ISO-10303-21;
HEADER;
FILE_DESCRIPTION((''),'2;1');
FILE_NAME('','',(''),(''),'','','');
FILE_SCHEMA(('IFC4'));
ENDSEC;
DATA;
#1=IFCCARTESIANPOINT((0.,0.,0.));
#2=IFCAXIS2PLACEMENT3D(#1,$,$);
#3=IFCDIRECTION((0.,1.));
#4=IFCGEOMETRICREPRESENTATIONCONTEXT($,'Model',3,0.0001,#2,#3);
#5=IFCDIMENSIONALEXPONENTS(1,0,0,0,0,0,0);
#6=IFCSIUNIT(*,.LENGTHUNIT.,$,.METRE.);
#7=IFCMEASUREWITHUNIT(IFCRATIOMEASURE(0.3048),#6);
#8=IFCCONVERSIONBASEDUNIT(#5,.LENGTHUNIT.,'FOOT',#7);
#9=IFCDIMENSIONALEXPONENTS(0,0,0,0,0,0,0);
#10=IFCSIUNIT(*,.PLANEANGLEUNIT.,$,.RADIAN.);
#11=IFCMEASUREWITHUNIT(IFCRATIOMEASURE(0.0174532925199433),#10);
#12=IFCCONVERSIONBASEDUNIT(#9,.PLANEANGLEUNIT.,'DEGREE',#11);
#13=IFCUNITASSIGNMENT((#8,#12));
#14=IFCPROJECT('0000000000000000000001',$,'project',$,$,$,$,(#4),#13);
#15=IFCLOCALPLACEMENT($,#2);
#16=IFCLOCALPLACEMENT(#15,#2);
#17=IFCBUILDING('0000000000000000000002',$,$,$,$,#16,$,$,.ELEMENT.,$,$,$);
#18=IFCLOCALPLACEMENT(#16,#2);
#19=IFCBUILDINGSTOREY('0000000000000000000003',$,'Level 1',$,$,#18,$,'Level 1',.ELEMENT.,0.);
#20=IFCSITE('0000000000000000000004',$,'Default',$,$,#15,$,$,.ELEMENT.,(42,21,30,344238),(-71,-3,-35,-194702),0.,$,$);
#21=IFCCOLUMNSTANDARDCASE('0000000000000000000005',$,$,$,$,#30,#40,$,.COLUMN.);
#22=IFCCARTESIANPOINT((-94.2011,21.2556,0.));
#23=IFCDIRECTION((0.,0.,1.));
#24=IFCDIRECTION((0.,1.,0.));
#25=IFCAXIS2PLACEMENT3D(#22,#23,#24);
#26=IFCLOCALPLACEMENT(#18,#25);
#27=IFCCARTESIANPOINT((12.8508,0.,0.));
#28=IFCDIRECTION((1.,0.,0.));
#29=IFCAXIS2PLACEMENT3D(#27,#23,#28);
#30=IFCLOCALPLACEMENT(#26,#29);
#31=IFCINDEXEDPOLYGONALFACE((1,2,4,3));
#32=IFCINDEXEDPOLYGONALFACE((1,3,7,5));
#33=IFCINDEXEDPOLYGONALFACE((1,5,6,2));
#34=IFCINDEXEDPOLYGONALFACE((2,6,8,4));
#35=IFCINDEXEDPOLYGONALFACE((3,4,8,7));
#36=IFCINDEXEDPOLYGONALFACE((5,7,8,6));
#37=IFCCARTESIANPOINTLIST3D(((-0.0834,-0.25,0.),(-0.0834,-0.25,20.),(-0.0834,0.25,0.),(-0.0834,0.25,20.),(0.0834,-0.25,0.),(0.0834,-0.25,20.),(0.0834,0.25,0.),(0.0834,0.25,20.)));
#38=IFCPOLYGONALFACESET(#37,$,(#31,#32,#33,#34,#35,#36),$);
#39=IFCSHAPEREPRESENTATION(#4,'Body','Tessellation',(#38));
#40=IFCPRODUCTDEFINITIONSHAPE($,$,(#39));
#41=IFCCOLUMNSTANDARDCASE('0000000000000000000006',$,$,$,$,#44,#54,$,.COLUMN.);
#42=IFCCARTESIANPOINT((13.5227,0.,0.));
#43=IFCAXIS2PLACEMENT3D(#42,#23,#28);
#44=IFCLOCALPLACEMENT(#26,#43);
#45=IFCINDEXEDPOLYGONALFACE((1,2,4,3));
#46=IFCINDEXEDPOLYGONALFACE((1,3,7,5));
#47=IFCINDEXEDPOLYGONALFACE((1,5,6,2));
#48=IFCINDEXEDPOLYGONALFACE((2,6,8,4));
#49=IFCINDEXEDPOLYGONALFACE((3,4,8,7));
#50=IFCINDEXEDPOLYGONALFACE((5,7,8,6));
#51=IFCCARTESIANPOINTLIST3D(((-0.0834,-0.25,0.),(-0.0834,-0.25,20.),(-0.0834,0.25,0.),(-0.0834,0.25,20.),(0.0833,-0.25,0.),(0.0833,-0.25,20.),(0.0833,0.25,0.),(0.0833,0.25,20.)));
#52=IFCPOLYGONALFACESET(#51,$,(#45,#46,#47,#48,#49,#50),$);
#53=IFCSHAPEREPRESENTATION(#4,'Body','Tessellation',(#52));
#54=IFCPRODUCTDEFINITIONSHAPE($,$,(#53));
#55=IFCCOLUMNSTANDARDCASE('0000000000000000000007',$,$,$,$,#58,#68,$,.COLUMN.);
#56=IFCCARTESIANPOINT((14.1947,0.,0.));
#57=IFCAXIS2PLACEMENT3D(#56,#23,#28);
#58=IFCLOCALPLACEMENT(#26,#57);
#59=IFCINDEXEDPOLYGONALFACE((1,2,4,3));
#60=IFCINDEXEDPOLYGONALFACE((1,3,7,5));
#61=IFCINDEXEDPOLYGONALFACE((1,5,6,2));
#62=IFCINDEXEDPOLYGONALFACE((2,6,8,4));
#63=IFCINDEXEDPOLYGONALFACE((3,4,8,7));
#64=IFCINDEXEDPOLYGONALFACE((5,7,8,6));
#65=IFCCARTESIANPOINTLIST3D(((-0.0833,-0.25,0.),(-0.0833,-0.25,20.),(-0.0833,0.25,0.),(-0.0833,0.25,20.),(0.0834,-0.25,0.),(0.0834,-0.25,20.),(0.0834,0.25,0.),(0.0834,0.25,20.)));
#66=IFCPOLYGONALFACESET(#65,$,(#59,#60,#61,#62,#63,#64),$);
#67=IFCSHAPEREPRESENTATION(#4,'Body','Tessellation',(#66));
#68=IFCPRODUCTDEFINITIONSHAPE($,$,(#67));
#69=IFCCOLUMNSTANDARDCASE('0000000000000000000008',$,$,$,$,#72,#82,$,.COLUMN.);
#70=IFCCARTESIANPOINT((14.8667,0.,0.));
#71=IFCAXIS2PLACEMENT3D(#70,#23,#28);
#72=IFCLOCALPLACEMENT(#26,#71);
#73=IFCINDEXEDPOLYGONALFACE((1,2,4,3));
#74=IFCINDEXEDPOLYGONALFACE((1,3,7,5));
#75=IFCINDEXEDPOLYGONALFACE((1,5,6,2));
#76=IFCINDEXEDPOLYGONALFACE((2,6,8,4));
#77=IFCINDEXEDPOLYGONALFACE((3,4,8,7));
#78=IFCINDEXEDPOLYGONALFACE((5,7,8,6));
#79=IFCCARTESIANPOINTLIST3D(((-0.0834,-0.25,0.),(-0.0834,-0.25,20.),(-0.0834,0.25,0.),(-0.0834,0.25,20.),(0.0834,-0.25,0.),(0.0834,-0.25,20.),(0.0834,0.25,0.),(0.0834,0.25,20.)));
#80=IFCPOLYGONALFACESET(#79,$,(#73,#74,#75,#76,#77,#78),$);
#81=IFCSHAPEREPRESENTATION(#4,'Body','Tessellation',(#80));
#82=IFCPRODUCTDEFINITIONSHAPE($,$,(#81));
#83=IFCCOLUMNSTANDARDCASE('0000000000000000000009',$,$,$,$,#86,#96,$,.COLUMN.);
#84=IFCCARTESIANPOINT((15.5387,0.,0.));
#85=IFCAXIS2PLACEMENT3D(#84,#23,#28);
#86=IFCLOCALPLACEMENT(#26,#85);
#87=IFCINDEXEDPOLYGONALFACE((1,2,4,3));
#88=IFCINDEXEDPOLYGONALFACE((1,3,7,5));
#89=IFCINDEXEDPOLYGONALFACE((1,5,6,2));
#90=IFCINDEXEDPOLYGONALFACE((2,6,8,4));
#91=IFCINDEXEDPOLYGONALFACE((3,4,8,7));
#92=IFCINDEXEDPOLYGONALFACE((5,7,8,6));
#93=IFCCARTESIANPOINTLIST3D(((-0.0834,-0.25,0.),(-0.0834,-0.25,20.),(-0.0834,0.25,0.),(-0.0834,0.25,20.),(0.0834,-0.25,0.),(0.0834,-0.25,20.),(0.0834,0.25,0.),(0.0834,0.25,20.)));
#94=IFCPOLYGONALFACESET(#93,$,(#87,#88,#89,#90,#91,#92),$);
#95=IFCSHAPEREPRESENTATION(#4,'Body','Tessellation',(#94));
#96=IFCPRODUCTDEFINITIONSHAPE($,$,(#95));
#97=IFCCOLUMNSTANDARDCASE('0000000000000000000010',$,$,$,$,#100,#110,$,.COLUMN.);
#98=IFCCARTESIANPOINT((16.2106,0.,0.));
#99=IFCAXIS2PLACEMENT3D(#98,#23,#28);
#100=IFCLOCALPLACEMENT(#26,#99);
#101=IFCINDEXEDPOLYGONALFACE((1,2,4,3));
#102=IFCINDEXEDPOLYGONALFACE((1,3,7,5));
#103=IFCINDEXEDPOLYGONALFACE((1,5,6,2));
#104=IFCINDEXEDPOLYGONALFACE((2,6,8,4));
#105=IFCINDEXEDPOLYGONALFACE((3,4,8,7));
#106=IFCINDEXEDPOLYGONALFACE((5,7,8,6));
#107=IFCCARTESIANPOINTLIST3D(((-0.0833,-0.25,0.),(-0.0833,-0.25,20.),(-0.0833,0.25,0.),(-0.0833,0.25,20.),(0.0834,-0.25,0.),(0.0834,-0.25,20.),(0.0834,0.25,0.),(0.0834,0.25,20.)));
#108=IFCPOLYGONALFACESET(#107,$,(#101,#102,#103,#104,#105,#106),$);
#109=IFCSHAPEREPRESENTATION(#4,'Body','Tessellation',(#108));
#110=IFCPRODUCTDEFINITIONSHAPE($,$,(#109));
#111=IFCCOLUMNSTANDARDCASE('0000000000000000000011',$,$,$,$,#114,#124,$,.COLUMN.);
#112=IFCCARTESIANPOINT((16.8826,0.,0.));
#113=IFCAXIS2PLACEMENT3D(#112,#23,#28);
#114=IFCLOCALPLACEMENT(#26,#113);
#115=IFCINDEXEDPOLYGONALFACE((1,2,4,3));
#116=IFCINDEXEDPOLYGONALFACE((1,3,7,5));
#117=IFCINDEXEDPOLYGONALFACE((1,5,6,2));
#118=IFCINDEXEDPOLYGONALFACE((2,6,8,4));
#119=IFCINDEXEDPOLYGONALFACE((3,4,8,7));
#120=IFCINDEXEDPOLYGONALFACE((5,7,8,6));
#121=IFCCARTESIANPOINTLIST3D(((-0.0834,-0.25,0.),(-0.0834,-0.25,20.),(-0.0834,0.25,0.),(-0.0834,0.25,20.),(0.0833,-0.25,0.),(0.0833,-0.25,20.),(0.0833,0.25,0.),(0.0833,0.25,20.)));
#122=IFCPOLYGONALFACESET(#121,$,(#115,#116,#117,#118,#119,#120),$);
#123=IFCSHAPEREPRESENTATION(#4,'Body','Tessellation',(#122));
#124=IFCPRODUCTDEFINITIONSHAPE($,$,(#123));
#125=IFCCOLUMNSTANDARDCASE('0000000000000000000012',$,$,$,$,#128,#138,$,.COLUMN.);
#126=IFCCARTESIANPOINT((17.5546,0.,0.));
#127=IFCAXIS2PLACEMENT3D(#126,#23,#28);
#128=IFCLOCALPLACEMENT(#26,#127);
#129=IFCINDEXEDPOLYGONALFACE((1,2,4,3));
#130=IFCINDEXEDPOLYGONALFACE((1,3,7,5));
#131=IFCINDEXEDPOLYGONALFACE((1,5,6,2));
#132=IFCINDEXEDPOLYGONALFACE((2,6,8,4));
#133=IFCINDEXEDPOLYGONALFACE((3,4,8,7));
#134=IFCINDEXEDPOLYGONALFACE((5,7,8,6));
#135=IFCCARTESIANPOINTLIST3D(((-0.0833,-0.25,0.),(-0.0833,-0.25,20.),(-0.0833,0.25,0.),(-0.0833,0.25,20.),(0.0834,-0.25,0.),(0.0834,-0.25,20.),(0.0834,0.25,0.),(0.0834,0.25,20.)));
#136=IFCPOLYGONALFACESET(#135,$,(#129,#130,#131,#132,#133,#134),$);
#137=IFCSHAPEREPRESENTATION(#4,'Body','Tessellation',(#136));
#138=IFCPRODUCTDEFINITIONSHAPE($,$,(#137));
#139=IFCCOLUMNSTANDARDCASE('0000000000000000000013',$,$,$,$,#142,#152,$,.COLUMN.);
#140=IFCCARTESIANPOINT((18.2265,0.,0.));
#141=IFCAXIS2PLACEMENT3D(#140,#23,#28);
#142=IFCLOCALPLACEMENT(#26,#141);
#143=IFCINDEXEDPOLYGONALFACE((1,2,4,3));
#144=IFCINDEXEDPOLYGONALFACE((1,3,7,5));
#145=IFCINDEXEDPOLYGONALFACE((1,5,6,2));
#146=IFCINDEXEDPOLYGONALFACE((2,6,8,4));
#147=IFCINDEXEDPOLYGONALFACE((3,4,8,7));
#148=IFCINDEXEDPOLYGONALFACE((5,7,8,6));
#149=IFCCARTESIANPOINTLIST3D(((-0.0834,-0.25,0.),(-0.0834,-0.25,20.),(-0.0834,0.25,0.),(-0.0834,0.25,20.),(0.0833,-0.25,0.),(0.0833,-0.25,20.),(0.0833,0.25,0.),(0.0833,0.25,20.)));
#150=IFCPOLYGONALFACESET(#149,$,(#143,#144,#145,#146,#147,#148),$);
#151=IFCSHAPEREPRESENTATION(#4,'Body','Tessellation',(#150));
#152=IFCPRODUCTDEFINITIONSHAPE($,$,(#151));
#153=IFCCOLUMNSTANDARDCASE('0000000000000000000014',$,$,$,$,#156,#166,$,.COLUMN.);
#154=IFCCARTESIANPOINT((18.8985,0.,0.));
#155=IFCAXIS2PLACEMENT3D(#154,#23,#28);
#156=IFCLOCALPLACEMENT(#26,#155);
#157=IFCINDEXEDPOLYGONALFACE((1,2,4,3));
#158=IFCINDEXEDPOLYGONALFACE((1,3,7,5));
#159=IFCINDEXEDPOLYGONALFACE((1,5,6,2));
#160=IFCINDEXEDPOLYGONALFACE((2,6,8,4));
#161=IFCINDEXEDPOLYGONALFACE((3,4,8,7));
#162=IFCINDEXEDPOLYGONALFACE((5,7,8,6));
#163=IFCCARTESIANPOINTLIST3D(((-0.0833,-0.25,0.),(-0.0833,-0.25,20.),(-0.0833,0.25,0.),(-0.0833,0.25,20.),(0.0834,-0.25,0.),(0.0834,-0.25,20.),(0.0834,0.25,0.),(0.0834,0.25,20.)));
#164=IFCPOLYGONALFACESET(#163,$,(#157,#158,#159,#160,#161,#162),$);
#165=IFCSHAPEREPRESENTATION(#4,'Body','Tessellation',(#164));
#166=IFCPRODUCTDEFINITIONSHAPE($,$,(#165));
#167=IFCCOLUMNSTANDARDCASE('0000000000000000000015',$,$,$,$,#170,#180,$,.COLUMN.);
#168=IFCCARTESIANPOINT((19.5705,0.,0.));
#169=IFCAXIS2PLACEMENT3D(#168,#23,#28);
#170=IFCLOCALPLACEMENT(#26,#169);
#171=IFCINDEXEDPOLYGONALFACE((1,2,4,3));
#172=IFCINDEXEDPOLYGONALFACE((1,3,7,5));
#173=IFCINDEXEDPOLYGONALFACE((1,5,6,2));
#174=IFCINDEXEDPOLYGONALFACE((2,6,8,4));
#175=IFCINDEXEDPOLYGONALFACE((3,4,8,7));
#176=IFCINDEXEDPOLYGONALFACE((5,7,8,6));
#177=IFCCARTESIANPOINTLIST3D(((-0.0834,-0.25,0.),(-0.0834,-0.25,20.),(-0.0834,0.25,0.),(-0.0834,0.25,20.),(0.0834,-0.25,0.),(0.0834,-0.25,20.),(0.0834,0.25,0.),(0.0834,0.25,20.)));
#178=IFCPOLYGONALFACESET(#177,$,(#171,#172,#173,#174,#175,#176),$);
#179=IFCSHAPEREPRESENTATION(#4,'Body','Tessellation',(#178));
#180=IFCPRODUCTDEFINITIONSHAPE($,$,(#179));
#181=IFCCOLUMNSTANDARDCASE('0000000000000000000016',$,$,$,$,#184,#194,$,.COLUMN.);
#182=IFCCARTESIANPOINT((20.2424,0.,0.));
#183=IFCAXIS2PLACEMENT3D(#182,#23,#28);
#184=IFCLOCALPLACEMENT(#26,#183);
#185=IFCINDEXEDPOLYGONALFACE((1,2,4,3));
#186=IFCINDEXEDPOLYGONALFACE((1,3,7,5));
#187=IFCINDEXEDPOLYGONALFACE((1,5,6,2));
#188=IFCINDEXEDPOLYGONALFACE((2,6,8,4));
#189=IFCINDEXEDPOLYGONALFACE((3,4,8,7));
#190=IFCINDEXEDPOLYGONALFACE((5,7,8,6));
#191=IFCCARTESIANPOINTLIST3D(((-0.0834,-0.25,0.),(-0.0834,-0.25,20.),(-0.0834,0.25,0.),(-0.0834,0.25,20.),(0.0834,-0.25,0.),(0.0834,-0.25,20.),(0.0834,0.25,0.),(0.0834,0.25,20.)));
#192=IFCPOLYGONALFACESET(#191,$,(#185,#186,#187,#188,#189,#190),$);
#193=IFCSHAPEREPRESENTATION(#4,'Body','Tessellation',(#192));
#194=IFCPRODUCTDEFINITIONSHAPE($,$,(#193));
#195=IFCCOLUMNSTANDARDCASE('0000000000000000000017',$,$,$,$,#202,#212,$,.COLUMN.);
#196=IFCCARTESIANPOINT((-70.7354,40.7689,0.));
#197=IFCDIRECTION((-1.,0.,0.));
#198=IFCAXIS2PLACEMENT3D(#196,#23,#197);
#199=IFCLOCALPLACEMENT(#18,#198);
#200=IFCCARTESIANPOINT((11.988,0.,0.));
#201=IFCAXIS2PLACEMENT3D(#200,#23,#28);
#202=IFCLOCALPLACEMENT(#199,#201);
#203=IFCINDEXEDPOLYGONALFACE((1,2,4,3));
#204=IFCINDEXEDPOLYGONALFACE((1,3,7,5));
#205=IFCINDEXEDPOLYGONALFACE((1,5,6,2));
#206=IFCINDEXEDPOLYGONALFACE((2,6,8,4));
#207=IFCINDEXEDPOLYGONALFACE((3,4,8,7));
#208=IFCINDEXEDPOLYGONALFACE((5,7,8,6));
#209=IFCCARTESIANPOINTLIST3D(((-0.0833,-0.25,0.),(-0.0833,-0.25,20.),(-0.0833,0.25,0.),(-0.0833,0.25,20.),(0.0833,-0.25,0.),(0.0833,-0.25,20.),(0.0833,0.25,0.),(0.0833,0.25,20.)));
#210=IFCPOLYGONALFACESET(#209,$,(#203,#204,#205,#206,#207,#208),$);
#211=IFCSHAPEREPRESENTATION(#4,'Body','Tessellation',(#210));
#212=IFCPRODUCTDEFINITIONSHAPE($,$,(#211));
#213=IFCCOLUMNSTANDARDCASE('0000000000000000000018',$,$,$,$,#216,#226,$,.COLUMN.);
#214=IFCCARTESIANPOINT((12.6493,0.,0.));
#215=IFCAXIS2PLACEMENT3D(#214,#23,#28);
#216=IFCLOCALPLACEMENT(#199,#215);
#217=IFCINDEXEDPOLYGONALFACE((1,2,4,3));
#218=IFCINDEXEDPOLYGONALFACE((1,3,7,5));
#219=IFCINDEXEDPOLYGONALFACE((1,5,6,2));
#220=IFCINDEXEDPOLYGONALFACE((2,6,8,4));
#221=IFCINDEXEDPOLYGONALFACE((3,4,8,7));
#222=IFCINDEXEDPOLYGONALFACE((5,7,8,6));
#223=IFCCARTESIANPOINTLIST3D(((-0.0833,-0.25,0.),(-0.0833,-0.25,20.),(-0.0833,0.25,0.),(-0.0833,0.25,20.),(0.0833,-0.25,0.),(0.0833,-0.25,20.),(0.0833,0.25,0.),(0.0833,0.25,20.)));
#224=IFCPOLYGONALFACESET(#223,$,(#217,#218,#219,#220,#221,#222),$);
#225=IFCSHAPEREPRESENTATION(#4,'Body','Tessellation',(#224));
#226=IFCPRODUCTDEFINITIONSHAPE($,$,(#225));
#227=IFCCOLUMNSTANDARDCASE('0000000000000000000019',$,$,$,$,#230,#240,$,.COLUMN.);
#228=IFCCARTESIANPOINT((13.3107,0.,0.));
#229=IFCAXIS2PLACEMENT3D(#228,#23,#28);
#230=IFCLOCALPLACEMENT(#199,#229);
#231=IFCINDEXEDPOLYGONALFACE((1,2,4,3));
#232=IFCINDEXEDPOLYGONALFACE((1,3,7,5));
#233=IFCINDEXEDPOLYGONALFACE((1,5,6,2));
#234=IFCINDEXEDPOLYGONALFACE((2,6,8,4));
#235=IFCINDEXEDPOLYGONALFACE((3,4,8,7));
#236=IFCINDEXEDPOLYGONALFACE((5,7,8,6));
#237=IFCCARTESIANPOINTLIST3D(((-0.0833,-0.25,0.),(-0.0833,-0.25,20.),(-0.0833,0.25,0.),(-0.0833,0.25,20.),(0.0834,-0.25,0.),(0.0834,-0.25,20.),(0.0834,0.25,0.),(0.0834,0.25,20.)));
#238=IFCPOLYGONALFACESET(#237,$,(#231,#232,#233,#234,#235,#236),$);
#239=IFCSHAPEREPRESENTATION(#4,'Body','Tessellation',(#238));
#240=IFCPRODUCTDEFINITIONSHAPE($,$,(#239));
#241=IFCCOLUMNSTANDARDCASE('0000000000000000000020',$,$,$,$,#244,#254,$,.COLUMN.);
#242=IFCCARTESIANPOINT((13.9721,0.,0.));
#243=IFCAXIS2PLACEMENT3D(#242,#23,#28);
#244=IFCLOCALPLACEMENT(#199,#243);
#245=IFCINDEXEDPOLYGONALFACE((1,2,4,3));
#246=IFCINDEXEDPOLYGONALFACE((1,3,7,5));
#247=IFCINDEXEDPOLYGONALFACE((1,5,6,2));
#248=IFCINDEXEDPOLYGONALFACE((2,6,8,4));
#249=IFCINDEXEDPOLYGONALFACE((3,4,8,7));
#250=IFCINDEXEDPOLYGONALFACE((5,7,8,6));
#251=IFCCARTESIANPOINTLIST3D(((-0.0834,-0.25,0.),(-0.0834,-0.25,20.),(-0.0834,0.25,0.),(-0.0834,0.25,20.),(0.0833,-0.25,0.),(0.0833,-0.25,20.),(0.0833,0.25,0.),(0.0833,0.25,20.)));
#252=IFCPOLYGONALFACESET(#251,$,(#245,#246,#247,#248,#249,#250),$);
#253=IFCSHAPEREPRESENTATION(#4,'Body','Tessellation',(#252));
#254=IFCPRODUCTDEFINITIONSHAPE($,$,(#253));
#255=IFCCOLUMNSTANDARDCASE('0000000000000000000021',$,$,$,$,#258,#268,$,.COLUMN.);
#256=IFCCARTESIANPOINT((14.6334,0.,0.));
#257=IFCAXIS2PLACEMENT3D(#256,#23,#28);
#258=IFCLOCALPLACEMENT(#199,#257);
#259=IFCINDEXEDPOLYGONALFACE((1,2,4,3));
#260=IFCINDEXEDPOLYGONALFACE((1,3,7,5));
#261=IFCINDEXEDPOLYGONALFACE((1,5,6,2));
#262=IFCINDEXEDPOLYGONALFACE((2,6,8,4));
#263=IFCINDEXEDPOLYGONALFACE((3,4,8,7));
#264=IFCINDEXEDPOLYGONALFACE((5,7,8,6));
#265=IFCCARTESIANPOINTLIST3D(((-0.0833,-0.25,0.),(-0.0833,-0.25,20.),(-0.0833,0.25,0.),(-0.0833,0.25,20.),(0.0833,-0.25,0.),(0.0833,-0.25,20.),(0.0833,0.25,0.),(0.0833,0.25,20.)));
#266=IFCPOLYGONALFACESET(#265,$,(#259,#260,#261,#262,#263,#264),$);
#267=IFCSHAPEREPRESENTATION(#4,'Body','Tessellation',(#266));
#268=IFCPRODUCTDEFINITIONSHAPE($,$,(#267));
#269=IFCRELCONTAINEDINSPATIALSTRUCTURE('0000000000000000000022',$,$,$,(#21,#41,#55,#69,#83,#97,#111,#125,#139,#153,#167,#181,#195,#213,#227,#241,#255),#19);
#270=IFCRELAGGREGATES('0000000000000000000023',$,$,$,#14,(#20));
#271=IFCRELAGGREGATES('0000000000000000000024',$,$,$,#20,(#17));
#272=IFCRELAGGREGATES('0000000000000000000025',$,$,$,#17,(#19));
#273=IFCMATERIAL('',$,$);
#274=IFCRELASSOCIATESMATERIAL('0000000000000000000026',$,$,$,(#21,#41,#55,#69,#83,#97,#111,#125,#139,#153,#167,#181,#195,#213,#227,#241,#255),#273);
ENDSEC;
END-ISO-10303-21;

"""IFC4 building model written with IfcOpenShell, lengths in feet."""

from ifc_helpers import new_model, entity, si_unit, converted_unit, direction, frame, origin, place, context, project, spatial, rectangle, extrude, material, element, save


model = new_model("IFC4")

# Units and contexts
model_context = context("Model", 3, precision=0.0001, world=origin(), true_north=direction((0.0, 1.0)))
ifc_project = project(units=[converted_unit("LENGTHUNIT", "FOOT", entity("IfcRatioMeasure", 0.3048), si_unit("LENGTHUNIT", "METRE"), dimensions=[1, 0, 0, 0, 0, 0, 0]), converted_unit("PLANEANGLEUNIT", "DEGREE", entity("IfcRatioMeasure", 0.0174532925199433), si_unit("PLANEANGLEUNIT", "RADIAN"), dimensions=[0, 0, 0, 0, 0, 0, 0])], contexts=[model_context])

# Site, building, storey
site_placement = place(None, origin())
site = spatial("IfcSite", under=ifc_project, at=site_placement, Name="Default", CompositionType="ELEMENT", RefLatitude=(42, 21, 30, 344238), RefLongitude=(-71, -3, -35, -194702), RefElevation=0.0)
building_placement = place(site_placement, origin())
building = spatial("IfcBuilding", under=site, at=building_placement, CompositionType="ELEMENT")
storey_placement = place(building_placement, origin())
storey = spatial("IfcBuildingStorey", under=building, at=storey_placement, Name="Level 1", LongName="Level 1", CompositionType="ELEMENT", Elevation=0.0)

# Columns
ifc_material_1 = material(Name="")
placement_1 = place(storey_placement, frame((-94.2011, 21.2556, 0.0), z_axis=(0.0, 0.0, 1.0), x_axis=(0.0, 1.0, 0.0)))
for number, where, z_axis, x_axis in (
    (1, (12.8508, 0.0, 0.0), (0.0, 0.0, 1.0), (1.0, 0.0, 0.0)),
    (2, (13.5227, 0.0, 0.0), (0.0, 0.0, 1.0), (1.0, 0.0, 0.0)),
    (3, (14.1947, 0.0, 0.0), (0.0, 0.0, 1.0), (1.0, 0.0, 0.0)),
    (4, (14.8667, 0.0, 0.0), (0.0, 0.0, 1.0), (1.0, 0.0, 0.0)),
    (5, (15.5387, 0.0, 0.0), (0.0, 0.0, 1.0), (1.0, 0.0, 0.0)),
    (6, (16.2106, 0.0, 0.0), (0.0, 0.0, 1.0), (1.0, 0.0, 0.0)),
    (7, (16.8826, 0.0, 0.0), (0.0, 0.0, 1.0), (1.0, 0.0, 0.0)),
    (8, (17.5546, 0.0, 0.0), (0.0, 0.0, 1.0), (1.0, 0.0, 0.0)),
    (9, (18.2265, 0.0, 0.0), (0.0, 0.0, 1.0), (1.0, 0.0, 0.0)),
    (10, (18.8985, 0.0, 0.0), (0.0, 0.0, 1.0), (1.0, 0.0, 0.0)),
    (11, (19.5705, 0.0, 0.0), (0.0, 0.0, 1.0), (1.0, 0.0, 0.0)),
    (12, (20.2424, 0.0, 0.0), (0.0, 0.0, 1.0), (1.0, 0.0, 0.0)),
):
    element("IfcColumnStandardCase", number, at=place(placement_1, frame(where, z_axis=z_axis, x_axis=x_axis)), inside=storey, material=ifc_material_1, PredefinedType="COLUMN", context=model_context, shape_type="SweptSolid", body=[
        extrude(rectangle(XDim=0.1667, YDim=0.5), origin(), (0.0, 0.0, 1.0), 20.0),
    ])
placement_2 = place(storey_placement, frame((-70.7354, 40.7689, 0.0), z_axis=(0.0, 0.0, 1.0), x_axis=(-1.0, 0.0, 0.0)))
for number, where, z_axis, x_axis in (
    (13, (11.988, 0.0, 0.0), (0.0, 0.0, 1.0), (1.0, 0.0, 0.0)),
    (14, (12.6493, 0.0, 0.0), (0.0, 0.0, 1.0), (1.0, 0.0, 0.0)),
    (15, (13.3107, 0.0, 0.0), (0.0, 0.0, 1.0), (1.0, 0.0, 0.0)),
    (16, (13.9721, 0.0, 0.0), (0.0, 0.0, 1.0), (1.0, 0.0, 0.0)),
    (17, (14.6334, 0.0, 0.0), (0.0, 0.0, 1.0), (1.0, 0.0, 0.0)),
):
    element("IfcColumnStandardCase", number, at=place(placement_2, frame(where, z_axis=z_axis, x_axis=x_axis)), inside=storey, material=ifc_material_1, PredefinedType="COLUMN", context=model_context, shape_type="SweptSolid", body=[
        extrude(rectangle(XDim=0.1667, YDim=0.5), origin(), (0.0, 0.0, 1.0), 20.0),
    ])

save(model, "model.ifc")
